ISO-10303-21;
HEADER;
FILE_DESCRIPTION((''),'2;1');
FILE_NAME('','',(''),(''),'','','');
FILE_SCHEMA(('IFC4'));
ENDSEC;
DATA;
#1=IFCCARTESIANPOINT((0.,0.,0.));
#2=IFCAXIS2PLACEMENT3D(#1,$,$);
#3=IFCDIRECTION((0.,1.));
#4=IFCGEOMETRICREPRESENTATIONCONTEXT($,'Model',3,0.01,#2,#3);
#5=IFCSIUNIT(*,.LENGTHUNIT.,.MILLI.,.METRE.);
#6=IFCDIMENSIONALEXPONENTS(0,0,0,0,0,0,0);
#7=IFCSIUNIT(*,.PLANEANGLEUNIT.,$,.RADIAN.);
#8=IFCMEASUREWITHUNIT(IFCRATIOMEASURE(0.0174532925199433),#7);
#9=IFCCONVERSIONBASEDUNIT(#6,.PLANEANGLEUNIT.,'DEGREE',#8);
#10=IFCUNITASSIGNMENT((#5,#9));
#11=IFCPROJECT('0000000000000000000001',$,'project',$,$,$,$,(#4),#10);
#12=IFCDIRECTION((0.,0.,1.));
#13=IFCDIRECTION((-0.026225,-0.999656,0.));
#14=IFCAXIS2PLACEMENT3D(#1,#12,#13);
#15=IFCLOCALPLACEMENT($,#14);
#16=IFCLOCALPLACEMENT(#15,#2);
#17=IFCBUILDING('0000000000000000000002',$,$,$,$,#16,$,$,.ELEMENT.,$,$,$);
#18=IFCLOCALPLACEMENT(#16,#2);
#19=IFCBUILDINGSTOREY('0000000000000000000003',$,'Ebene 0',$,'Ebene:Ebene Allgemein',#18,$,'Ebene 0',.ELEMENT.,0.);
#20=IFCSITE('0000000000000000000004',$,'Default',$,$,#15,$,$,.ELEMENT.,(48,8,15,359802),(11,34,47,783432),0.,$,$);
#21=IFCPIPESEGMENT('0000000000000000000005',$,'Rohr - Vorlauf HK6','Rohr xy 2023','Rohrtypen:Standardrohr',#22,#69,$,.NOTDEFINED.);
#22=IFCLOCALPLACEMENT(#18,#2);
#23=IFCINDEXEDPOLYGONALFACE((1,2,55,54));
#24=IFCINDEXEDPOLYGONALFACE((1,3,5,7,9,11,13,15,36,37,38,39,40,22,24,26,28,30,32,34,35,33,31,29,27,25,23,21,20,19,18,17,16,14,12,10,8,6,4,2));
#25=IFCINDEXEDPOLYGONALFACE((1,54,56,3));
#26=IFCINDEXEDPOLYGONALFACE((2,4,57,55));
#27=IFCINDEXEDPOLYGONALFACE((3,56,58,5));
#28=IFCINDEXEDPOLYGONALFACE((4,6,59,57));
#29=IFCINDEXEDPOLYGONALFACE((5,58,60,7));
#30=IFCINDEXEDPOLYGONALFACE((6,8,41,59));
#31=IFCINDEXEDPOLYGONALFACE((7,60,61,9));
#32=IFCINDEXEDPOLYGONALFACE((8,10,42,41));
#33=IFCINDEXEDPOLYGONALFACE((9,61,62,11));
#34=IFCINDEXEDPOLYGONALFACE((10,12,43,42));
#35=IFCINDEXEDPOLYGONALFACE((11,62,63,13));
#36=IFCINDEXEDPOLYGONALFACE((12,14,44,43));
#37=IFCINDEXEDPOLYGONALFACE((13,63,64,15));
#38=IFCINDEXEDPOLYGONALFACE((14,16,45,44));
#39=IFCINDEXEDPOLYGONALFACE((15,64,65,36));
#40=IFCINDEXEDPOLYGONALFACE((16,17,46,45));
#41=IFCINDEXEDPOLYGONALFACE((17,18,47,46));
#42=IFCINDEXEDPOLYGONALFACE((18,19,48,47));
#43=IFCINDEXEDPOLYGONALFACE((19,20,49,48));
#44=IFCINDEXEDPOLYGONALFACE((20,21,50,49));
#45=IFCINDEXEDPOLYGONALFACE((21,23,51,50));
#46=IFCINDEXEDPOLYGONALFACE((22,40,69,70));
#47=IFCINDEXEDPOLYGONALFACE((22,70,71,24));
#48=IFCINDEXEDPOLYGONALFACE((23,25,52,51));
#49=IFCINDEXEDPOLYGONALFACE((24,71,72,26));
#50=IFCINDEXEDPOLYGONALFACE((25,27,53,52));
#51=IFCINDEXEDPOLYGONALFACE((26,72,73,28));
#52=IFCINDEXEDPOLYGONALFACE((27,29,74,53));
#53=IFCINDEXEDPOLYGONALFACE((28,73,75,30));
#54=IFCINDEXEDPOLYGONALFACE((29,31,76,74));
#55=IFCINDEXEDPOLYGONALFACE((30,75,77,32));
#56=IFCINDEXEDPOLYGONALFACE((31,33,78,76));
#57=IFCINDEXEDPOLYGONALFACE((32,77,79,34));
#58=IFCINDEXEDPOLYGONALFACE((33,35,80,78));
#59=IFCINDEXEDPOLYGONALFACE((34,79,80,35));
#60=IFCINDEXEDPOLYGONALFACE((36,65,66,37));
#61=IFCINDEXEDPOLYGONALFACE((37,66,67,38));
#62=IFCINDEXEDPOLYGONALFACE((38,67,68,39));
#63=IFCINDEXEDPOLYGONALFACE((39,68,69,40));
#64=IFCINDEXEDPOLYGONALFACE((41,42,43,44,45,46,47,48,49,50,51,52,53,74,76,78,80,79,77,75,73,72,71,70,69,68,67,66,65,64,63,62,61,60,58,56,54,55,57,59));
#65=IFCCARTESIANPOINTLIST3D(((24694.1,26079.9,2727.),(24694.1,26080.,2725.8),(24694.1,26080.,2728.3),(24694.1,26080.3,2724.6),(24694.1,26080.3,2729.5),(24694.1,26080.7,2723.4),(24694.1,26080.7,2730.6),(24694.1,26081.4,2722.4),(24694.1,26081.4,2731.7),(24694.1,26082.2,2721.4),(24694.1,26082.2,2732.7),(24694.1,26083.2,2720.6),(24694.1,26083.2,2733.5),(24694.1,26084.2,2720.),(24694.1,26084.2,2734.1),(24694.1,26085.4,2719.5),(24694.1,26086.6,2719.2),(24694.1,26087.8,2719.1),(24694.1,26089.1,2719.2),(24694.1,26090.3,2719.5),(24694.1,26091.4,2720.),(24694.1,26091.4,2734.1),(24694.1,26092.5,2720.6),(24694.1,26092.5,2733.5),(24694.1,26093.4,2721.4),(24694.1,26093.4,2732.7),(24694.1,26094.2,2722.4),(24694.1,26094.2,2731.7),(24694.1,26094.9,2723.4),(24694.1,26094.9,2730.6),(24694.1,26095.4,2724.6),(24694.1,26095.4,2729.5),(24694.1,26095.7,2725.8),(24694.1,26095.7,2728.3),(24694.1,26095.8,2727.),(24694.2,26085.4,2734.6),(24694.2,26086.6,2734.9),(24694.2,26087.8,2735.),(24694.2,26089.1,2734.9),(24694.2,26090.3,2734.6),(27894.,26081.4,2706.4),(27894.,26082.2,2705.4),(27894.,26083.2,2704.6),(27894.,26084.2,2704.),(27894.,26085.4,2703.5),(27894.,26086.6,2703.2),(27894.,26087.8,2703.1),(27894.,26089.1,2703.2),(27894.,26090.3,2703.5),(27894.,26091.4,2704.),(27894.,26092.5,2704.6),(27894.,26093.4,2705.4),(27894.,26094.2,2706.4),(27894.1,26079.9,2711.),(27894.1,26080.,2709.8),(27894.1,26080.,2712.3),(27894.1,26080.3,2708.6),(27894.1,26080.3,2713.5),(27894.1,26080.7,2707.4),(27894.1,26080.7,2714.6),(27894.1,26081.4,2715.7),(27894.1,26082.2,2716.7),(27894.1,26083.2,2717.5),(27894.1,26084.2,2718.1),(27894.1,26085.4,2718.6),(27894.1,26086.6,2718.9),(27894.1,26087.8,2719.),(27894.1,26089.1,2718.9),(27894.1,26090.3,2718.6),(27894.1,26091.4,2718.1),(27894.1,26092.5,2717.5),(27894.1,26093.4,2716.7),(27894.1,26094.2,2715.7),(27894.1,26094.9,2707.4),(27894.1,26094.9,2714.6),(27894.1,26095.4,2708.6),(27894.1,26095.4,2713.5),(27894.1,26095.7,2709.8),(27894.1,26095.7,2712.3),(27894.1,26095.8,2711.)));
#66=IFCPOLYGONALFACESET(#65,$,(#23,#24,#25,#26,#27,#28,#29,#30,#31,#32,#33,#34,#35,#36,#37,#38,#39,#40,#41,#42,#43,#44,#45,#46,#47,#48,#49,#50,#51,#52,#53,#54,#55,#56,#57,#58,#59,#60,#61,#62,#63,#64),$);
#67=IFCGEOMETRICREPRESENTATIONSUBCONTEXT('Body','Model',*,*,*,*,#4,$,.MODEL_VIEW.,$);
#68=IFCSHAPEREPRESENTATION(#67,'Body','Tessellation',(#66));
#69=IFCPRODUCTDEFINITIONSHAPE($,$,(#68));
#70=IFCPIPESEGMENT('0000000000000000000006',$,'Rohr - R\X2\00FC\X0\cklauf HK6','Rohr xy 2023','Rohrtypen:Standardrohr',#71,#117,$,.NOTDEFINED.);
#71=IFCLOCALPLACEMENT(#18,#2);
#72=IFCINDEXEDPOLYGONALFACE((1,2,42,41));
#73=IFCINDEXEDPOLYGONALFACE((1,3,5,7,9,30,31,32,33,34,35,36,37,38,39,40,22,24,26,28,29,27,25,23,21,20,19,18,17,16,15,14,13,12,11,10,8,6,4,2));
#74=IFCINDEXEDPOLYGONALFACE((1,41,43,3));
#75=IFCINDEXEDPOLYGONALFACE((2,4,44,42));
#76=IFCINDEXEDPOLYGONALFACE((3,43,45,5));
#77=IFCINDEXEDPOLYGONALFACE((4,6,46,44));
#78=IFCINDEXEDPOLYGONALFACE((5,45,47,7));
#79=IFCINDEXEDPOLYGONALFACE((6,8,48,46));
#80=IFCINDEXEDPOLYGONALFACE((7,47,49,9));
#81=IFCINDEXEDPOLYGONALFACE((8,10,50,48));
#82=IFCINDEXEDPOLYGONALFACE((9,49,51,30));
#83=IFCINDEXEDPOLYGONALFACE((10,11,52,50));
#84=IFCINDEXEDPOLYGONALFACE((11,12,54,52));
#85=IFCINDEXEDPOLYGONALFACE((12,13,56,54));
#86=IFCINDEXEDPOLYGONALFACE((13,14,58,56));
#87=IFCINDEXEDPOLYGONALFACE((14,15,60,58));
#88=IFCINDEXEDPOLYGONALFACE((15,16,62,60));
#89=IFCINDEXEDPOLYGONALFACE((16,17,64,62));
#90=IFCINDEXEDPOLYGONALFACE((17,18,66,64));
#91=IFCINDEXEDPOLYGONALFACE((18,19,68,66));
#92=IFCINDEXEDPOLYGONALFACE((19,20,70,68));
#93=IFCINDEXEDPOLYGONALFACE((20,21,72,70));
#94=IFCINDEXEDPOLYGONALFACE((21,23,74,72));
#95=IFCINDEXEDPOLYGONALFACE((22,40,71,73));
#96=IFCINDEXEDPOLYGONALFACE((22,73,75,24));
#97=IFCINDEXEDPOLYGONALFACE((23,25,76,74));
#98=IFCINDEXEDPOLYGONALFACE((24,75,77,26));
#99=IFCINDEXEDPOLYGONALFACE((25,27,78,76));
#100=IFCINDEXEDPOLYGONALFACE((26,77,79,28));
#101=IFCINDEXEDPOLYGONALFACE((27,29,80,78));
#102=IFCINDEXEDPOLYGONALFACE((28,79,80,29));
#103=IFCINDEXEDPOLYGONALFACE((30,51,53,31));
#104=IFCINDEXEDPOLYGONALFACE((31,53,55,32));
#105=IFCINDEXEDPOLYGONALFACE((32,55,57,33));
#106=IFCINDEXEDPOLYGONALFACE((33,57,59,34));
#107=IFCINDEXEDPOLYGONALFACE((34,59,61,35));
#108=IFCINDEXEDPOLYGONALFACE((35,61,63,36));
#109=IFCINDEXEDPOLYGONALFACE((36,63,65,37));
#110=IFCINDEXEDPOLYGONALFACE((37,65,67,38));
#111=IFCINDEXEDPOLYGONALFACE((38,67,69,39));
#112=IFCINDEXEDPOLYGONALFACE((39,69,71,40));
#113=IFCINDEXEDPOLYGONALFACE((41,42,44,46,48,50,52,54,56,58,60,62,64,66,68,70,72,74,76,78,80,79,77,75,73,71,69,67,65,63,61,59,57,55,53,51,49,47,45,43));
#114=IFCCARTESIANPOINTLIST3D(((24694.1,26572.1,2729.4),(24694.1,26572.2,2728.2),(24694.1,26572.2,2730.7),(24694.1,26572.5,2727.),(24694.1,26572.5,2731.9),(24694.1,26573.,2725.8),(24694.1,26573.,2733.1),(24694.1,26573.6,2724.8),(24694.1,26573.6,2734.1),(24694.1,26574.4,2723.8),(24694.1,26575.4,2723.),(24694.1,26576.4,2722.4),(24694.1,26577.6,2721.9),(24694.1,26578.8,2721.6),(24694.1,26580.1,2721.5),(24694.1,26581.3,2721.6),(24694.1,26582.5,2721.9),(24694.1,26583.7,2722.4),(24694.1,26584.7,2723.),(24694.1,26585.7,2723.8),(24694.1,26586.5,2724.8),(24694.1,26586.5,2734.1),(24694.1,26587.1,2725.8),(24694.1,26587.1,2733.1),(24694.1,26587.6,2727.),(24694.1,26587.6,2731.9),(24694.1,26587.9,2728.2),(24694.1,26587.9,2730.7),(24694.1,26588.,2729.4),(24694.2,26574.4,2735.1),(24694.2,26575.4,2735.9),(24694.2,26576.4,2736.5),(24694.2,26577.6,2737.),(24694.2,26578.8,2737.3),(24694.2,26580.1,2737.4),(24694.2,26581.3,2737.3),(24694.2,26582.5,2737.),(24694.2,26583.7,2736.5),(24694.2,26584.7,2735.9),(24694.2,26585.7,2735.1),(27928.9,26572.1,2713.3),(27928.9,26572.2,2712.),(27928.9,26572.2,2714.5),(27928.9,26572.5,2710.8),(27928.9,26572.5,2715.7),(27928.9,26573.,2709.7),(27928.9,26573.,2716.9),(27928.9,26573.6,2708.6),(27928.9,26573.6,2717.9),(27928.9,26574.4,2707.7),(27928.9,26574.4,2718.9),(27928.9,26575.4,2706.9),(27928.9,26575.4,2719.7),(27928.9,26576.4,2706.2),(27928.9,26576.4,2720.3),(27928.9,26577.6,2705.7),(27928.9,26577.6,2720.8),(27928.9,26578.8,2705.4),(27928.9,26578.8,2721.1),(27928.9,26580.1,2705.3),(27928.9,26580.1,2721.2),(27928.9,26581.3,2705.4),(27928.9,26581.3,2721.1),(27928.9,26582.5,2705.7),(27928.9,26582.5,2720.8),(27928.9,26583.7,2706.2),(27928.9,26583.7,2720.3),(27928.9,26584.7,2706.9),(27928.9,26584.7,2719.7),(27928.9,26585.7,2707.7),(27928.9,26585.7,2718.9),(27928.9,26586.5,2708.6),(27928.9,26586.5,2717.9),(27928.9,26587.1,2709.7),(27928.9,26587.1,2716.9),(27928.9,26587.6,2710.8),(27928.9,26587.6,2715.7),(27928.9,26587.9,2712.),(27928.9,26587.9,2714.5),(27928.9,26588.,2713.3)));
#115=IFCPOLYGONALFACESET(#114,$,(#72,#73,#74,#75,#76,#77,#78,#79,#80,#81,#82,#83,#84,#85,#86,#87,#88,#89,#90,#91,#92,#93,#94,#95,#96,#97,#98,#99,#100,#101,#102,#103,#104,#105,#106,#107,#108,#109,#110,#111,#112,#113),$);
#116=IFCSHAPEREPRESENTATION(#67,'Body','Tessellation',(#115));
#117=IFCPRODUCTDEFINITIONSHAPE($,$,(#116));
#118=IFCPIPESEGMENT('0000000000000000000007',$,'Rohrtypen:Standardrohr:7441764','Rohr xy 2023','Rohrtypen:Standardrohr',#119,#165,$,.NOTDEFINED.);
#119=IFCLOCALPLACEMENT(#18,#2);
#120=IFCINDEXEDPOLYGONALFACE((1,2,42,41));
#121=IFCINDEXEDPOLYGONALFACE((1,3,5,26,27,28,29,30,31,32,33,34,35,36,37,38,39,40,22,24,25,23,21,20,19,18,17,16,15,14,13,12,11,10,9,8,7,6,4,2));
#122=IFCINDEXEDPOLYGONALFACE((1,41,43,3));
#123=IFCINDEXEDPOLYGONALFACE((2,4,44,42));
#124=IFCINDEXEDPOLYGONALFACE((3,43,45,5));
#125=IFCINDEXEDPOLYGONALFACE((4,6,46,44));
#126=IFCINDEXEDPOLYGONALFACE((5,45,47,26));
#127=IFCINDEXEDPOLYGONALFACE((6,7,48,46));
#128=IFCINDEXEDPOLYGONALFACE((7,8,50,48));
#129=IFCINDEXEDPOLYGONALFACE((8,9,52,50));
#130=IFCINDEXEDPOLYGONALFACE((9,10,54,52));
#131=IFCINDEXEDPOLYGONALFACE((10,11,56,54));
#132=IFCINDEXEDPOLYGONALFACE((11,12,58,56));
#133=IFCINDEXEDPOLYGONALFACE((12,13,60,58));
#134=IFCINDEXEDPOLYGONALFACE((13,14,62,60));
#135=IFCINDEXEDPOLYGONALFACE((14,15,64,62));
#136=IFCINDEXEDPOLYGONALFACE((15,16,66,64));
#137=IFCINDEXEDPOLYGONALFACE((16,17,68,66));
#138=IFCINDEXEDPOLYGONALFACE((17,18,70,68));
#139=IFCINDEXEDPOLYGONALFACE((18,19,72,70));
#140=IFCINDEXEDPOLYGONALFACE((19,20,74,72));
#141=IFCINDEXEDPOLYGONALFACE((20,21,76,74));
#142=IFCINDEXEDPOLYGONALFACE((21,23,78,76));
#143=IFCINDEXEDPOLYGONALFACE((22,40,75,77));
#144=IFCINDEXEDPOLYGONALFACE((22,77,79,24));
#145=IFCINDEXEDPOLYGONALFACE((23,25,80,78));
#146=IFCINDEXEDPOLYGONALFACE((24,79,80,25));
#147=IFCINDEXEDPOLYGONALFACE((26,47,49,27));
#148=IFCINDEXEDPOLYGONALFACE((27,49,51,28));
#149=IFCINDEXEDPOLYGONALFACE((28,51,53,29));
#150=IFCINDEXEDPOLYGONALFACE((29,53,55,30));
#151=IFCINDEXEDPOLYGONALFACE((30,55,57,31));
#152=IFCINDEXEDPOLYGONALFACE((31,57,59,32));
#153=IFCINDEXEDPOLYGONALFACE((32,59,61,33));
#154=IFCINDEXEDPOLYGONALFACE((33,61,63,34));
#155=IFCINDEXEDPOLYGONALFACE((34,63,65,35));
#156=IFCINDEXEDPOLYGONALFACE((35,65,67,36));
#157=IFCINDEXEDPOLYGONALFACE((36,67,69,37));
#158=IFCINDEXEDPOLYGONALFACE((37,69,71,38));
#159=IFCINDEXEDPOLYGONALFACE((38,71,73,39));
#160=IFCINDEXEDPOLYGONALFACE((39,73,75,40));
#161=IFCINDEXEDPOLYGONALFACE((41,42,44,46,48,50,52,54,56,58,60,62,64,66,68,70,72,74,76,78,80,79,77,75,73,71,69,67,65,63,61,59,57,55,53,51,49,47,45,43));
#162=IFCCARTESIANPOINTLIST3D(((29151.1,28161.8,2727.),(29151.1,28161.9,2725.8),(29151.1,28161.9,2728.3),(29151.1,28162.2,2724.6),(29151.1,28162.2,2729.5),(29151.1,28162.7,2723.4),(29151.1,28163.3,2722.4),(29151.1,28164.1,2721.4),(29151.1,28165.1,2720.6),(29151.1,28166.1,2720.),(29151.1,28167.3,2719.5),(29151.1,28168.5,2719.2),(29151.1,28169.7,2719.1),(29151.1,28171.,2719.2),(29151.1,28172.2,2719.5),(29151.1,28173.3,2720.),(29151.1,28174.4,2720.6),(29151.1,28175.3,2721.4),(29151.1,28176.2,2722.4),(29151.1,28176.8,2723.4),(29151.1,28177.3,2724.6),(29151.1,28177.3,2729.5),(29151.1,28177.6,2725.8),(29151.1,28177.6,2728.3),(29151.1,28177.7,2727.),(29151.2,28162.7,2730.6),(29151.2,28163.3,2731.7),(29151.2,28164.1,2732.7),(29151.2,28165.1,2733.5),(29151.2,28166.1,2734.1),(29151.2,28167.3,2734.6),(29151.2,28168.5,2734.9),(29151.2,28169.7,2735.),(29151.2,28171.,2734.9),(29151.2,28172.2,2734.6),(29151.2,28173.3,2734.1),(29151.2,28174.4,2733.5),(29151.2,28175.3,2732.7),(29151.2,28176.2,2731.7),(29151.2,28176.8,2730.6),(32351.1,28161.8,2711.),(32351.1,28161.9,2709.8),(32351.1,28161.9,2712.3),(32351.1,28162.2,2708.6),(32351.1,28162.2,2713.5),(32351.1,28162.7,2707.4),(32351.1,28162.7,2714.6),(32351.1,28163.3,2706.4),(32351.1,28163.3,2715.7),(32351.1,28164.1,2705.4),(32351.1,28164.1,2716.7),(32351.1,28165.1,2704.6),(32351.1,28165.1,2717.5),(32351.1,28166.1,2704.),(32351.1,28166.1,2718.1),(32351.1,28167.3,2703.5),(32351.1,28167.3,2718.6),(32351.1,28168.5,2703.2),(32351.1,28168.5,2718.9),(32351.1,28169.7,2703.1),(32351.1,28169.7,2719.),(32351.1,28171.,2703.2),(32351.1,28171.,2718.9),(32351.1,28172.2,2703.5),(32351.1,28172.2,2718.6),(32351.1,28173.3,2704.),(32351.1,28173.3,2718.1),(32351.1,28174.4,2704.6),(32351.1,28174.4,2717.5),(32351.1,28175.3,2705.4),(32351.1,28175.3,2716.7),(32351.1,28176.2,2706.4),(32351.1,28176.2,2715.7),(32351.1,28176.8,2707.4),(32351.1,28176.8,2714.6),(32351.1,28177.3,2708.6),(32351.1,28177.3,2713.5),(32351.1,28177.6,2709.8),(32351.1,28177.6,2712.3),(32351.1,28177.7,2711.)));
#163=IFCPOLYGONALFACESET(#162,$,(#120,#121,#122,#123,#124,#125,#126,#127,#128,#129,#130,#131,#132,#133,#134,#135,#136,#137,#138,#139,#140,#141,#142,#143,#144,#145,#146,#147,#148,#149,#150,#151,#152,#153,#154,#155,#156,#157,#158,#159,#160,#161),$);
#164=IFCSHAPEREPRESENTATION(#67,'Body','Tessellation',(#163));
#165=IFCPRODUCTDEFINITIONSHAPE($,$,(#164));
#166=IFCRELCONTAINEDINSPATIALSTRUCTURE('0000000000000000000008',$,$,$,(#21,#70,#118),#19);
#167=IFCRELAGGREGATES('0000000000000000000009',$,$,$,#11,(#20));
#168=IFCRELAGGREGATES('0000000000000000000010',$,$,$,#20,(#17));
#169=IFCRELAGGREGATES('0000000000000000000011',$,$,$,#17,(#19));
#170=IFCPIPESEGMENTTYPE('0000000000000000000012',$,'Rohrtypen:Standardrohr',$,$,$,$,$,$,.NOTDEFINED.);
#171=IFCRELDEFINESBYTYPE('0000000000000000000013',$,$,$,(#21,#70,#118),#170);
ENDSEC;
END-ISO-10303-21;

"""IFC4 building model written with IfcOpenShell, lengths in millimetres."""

from ifc_helpers import new_model, entity, si_unit, converted_unit, direction, frame, origin, place, context, subcontext, project, spatial, indexed_curve, outline, extrude, type_object, element, save


model = new_model("IFC4")

# Units and contexts
model_context = context("Model", 3, precision=0.01, world=origin(), true_north=direction((0.0, 1.0)))
body_context = subcontext(model_context, "Body", "Model", "MODEL_VIEW")
ifc_project = project(units=[si_unit("LENGTHUNIT", "METRE", prefix="MILLI"), converted_unit("PLANEANGLEUNIT", "DEGREE", entity("IfcRatioMeasure", 0.0174532925199433), si_unit("PLANEANGLEUNIT", "RADIAN"), dimensions=[0, 0, 0, 0, 0, 0, 0])], contexts=[model_context])

# Site, building, storey
site_placement = place(None, frame((0.0, 0.0, 0.0), z_axis=(0.0, 0.0, 1.0), x_axis=(-0.026225, -0.999656, 0.0)))
site = spatial("IfcSite", under=ifc_project, at=site_placement, Name="Default", CompositionType="ELEMENT", RefLatitude=(48, 8, 15, 359802), RefLongitude=(11, 34, 47, 783432), RefElevation=0.0)
building_placement = place(site_placement, origin())
building = spatial("IfcBuilding", under=site, at=building_placement, CompositionType="ELEMENT")
storey_placement = place(building_placement, origin())
storey = spatial("IfcBuildingStorey", under=building, at=storey_placement, Name="Ebene 0", ObjectType="Ebene:Ebene Allgemein", LongName="Ebene 0", CompositionType="ELEMENT", Elevation=0.0)

# Pipe segments
pipe_segment_type = type_object("IfcPipeSegmentType", Name="Rohrtypen:Standardrohr", PredefinedType="NOTDEFINED")
pipe_segment_1_placement = place(storey_placement, origin())
element("IfcPipeSegment", 1, at=pipe_segment_1_placement, inside=storey, type_object=pipe_segment_type, Name="Rohr - Vorlauf HK6", Description="Rohr xy 2023", ObjectType="Rohrtypen:Standardrohr", PredefinedType="NOTDEFINED", context=body_context, shape_type="SweptSolid", body=[
    extrude(outline(indexed_curve([(7.9, 0.0), (7.8, 1.2), (7.6, 2.5), (7.1, 3.6), (6.4, 4.7), (5.6, 5.6), (4.7, 6.4), (3.6, 7.1), (2.5, 7.6), (1.2, 7.8), (0.0, 7.9), (-1.2, 7.8), (-2.5, 7.6), (-3.6, 7.1), (-4.7, 6.4), (-5.6, 5.6), (-6.4, 4.7), (-7.1, 3.6), (-7.6, 2.5), (-7.8, 1.2), (-7.9, 0.0), (-7.8, -1.2), (-7.6, -2.5), (-7.1, -3.6), (-6.4, -4.7), (-5.6, -5.6), (-4.7, -6.4), (-3.6, -7.1), (-2.5, -7.6), (-1.2, -7.8), (0.0, -7.9), (1.2, -7.8), (2.5, -7.6), (3.6, -7.1), (4.7, -6.4), (5.6, -5.6), (6.4, -4.7), (7.1, -3.6), (7.6, -2.5), (7.8, -1.2), (7.9, 0.0)], self_intersect=False)), frame((27894.1, 26087.8, 2711.0), z_axis=(-0.999988, 0.0, 0.005), x_axis=(0.0, 1.0, 0.0)), (0.0, 0.0, 1.0), 3200.0),
])
pipe_segment_2_placement = place(storey_placement, origin())
element("IfcPipeSegment", 2, at=pipe_segment_2_placement, inside=storey, type_object=pipe_segment_type, Name="Rohr - Rücklauf HK6", Description="Rohr xy 2023", ObjectType="Rohrtypen:Standardrohr", PredefinedType="NOTDEFINED", context=body_context, shape_type="SweptSolid", body=[
    extrude(outline(indexed_curve([(7.9, 0.0), (7.8, 1.2), (7.6, 2.5), (7.1, 3.6), (6.4, 4.7), (5.6, 5.6), (4.7, 6.4), (3.6, 7.1), (2.5, 7.6), (1.2, 7.8), (0.0, 7.9), (-1.2, 7.8), (-2.5, 7.6), (-3.6, 7.1), (-4.7, 6.4), (-5.6, 5.6), (-6.4, 4.7), (-7.1, 3.6), (-7.6, 2.5), (-7.8, 1.2), (-7.9, 0.0), (-7.8, -1.2), (-7.6, -2.5), (-7.1, -3.6), (-6.4, -4.7), (-5.6, -5.6), (-4.7, -6.4), (-3.6, -7.1), (-2.5, -7.6), (-1.2, -7.8), (0.0, -7.9), (1.2, -7.8), (2.5, -7.6), (3.6, -7.1), (4.7, -6.4), (5.6, -5.6), (6.4, -4.7), (7.1, -3.6), (7.6, -2.5), (7.8, -1.2), (7.9, 0.0)], self_intersect=False)), frame((27928.9, 26580.1, 2713.3), z_axis=(-0.999988, 0.0, 0.005), x_axis=(0.0, 1.0, 0.0)), (0.0, 0.0, 1.0), 3234.8),
])
pipe_segment_3_placement = place(storey_placement, origin())
element("IfcPipeSegment", 3, at=pipe_segment_3_placement, inside=storey, type_object=pipe_segment_type, Name="Rohrtypen:Standardrohr:7441764", Description="Rohr xy 2023", ObjectType="Rohrtypen:Standardrohr", PredefinedType="NOTDEFINED", context=body_context, shape_type="SweptSolid", body=[
    extrude(outline(indexed_curve([(7.9, 0.0), (7.8, 1.2), (7.6, 2.5), (7.1, 3.6), (6.4, 4.7), (5.6, 5.6), (4.7, 6.4), (3.6, 7.1), (2.5, 7.6), (1.2, 7.8), (0.0, 7.9), (-1.2, 7.8), (-2.5, 7.6), (-3.6, 7.1), (-4.7, 6.4), (-5.6, 5.6), (-6.4, 4.7), (-7.1, 3.6), (-7.6, 2.5), (-7.8, 1.2), (-7.9, 0.0), (-7.8, -1.2), (-7.6, -2.5), (-7.1, -3.6), (-6.4, -4.7), (-5.6, -5.6), (-4.7, -6.4), (-3.6, -7.1), (-2.5, -7.6), (-1.2, -7.8), (0.0, -7.9), (1.2, -7.8), (2.5, -7.6), (3.6, -7.1), (4.7, -6.4), (5.6, -5.6), (6.4, -4.7), (7.1, -3.6), (7.6, -2.5), (7.8, -1.2), (7.9, 0.0)], self_intersect=False)), frame((32351.1, 28169.7, 2711.0), z_axis=(-0.999988, 0.0, 0.005), x_axis=(0.0, 1.0, 0.0)), (0.0, 0.0, 1.0), 3200.0),
])

save(model, "model.ifc")
